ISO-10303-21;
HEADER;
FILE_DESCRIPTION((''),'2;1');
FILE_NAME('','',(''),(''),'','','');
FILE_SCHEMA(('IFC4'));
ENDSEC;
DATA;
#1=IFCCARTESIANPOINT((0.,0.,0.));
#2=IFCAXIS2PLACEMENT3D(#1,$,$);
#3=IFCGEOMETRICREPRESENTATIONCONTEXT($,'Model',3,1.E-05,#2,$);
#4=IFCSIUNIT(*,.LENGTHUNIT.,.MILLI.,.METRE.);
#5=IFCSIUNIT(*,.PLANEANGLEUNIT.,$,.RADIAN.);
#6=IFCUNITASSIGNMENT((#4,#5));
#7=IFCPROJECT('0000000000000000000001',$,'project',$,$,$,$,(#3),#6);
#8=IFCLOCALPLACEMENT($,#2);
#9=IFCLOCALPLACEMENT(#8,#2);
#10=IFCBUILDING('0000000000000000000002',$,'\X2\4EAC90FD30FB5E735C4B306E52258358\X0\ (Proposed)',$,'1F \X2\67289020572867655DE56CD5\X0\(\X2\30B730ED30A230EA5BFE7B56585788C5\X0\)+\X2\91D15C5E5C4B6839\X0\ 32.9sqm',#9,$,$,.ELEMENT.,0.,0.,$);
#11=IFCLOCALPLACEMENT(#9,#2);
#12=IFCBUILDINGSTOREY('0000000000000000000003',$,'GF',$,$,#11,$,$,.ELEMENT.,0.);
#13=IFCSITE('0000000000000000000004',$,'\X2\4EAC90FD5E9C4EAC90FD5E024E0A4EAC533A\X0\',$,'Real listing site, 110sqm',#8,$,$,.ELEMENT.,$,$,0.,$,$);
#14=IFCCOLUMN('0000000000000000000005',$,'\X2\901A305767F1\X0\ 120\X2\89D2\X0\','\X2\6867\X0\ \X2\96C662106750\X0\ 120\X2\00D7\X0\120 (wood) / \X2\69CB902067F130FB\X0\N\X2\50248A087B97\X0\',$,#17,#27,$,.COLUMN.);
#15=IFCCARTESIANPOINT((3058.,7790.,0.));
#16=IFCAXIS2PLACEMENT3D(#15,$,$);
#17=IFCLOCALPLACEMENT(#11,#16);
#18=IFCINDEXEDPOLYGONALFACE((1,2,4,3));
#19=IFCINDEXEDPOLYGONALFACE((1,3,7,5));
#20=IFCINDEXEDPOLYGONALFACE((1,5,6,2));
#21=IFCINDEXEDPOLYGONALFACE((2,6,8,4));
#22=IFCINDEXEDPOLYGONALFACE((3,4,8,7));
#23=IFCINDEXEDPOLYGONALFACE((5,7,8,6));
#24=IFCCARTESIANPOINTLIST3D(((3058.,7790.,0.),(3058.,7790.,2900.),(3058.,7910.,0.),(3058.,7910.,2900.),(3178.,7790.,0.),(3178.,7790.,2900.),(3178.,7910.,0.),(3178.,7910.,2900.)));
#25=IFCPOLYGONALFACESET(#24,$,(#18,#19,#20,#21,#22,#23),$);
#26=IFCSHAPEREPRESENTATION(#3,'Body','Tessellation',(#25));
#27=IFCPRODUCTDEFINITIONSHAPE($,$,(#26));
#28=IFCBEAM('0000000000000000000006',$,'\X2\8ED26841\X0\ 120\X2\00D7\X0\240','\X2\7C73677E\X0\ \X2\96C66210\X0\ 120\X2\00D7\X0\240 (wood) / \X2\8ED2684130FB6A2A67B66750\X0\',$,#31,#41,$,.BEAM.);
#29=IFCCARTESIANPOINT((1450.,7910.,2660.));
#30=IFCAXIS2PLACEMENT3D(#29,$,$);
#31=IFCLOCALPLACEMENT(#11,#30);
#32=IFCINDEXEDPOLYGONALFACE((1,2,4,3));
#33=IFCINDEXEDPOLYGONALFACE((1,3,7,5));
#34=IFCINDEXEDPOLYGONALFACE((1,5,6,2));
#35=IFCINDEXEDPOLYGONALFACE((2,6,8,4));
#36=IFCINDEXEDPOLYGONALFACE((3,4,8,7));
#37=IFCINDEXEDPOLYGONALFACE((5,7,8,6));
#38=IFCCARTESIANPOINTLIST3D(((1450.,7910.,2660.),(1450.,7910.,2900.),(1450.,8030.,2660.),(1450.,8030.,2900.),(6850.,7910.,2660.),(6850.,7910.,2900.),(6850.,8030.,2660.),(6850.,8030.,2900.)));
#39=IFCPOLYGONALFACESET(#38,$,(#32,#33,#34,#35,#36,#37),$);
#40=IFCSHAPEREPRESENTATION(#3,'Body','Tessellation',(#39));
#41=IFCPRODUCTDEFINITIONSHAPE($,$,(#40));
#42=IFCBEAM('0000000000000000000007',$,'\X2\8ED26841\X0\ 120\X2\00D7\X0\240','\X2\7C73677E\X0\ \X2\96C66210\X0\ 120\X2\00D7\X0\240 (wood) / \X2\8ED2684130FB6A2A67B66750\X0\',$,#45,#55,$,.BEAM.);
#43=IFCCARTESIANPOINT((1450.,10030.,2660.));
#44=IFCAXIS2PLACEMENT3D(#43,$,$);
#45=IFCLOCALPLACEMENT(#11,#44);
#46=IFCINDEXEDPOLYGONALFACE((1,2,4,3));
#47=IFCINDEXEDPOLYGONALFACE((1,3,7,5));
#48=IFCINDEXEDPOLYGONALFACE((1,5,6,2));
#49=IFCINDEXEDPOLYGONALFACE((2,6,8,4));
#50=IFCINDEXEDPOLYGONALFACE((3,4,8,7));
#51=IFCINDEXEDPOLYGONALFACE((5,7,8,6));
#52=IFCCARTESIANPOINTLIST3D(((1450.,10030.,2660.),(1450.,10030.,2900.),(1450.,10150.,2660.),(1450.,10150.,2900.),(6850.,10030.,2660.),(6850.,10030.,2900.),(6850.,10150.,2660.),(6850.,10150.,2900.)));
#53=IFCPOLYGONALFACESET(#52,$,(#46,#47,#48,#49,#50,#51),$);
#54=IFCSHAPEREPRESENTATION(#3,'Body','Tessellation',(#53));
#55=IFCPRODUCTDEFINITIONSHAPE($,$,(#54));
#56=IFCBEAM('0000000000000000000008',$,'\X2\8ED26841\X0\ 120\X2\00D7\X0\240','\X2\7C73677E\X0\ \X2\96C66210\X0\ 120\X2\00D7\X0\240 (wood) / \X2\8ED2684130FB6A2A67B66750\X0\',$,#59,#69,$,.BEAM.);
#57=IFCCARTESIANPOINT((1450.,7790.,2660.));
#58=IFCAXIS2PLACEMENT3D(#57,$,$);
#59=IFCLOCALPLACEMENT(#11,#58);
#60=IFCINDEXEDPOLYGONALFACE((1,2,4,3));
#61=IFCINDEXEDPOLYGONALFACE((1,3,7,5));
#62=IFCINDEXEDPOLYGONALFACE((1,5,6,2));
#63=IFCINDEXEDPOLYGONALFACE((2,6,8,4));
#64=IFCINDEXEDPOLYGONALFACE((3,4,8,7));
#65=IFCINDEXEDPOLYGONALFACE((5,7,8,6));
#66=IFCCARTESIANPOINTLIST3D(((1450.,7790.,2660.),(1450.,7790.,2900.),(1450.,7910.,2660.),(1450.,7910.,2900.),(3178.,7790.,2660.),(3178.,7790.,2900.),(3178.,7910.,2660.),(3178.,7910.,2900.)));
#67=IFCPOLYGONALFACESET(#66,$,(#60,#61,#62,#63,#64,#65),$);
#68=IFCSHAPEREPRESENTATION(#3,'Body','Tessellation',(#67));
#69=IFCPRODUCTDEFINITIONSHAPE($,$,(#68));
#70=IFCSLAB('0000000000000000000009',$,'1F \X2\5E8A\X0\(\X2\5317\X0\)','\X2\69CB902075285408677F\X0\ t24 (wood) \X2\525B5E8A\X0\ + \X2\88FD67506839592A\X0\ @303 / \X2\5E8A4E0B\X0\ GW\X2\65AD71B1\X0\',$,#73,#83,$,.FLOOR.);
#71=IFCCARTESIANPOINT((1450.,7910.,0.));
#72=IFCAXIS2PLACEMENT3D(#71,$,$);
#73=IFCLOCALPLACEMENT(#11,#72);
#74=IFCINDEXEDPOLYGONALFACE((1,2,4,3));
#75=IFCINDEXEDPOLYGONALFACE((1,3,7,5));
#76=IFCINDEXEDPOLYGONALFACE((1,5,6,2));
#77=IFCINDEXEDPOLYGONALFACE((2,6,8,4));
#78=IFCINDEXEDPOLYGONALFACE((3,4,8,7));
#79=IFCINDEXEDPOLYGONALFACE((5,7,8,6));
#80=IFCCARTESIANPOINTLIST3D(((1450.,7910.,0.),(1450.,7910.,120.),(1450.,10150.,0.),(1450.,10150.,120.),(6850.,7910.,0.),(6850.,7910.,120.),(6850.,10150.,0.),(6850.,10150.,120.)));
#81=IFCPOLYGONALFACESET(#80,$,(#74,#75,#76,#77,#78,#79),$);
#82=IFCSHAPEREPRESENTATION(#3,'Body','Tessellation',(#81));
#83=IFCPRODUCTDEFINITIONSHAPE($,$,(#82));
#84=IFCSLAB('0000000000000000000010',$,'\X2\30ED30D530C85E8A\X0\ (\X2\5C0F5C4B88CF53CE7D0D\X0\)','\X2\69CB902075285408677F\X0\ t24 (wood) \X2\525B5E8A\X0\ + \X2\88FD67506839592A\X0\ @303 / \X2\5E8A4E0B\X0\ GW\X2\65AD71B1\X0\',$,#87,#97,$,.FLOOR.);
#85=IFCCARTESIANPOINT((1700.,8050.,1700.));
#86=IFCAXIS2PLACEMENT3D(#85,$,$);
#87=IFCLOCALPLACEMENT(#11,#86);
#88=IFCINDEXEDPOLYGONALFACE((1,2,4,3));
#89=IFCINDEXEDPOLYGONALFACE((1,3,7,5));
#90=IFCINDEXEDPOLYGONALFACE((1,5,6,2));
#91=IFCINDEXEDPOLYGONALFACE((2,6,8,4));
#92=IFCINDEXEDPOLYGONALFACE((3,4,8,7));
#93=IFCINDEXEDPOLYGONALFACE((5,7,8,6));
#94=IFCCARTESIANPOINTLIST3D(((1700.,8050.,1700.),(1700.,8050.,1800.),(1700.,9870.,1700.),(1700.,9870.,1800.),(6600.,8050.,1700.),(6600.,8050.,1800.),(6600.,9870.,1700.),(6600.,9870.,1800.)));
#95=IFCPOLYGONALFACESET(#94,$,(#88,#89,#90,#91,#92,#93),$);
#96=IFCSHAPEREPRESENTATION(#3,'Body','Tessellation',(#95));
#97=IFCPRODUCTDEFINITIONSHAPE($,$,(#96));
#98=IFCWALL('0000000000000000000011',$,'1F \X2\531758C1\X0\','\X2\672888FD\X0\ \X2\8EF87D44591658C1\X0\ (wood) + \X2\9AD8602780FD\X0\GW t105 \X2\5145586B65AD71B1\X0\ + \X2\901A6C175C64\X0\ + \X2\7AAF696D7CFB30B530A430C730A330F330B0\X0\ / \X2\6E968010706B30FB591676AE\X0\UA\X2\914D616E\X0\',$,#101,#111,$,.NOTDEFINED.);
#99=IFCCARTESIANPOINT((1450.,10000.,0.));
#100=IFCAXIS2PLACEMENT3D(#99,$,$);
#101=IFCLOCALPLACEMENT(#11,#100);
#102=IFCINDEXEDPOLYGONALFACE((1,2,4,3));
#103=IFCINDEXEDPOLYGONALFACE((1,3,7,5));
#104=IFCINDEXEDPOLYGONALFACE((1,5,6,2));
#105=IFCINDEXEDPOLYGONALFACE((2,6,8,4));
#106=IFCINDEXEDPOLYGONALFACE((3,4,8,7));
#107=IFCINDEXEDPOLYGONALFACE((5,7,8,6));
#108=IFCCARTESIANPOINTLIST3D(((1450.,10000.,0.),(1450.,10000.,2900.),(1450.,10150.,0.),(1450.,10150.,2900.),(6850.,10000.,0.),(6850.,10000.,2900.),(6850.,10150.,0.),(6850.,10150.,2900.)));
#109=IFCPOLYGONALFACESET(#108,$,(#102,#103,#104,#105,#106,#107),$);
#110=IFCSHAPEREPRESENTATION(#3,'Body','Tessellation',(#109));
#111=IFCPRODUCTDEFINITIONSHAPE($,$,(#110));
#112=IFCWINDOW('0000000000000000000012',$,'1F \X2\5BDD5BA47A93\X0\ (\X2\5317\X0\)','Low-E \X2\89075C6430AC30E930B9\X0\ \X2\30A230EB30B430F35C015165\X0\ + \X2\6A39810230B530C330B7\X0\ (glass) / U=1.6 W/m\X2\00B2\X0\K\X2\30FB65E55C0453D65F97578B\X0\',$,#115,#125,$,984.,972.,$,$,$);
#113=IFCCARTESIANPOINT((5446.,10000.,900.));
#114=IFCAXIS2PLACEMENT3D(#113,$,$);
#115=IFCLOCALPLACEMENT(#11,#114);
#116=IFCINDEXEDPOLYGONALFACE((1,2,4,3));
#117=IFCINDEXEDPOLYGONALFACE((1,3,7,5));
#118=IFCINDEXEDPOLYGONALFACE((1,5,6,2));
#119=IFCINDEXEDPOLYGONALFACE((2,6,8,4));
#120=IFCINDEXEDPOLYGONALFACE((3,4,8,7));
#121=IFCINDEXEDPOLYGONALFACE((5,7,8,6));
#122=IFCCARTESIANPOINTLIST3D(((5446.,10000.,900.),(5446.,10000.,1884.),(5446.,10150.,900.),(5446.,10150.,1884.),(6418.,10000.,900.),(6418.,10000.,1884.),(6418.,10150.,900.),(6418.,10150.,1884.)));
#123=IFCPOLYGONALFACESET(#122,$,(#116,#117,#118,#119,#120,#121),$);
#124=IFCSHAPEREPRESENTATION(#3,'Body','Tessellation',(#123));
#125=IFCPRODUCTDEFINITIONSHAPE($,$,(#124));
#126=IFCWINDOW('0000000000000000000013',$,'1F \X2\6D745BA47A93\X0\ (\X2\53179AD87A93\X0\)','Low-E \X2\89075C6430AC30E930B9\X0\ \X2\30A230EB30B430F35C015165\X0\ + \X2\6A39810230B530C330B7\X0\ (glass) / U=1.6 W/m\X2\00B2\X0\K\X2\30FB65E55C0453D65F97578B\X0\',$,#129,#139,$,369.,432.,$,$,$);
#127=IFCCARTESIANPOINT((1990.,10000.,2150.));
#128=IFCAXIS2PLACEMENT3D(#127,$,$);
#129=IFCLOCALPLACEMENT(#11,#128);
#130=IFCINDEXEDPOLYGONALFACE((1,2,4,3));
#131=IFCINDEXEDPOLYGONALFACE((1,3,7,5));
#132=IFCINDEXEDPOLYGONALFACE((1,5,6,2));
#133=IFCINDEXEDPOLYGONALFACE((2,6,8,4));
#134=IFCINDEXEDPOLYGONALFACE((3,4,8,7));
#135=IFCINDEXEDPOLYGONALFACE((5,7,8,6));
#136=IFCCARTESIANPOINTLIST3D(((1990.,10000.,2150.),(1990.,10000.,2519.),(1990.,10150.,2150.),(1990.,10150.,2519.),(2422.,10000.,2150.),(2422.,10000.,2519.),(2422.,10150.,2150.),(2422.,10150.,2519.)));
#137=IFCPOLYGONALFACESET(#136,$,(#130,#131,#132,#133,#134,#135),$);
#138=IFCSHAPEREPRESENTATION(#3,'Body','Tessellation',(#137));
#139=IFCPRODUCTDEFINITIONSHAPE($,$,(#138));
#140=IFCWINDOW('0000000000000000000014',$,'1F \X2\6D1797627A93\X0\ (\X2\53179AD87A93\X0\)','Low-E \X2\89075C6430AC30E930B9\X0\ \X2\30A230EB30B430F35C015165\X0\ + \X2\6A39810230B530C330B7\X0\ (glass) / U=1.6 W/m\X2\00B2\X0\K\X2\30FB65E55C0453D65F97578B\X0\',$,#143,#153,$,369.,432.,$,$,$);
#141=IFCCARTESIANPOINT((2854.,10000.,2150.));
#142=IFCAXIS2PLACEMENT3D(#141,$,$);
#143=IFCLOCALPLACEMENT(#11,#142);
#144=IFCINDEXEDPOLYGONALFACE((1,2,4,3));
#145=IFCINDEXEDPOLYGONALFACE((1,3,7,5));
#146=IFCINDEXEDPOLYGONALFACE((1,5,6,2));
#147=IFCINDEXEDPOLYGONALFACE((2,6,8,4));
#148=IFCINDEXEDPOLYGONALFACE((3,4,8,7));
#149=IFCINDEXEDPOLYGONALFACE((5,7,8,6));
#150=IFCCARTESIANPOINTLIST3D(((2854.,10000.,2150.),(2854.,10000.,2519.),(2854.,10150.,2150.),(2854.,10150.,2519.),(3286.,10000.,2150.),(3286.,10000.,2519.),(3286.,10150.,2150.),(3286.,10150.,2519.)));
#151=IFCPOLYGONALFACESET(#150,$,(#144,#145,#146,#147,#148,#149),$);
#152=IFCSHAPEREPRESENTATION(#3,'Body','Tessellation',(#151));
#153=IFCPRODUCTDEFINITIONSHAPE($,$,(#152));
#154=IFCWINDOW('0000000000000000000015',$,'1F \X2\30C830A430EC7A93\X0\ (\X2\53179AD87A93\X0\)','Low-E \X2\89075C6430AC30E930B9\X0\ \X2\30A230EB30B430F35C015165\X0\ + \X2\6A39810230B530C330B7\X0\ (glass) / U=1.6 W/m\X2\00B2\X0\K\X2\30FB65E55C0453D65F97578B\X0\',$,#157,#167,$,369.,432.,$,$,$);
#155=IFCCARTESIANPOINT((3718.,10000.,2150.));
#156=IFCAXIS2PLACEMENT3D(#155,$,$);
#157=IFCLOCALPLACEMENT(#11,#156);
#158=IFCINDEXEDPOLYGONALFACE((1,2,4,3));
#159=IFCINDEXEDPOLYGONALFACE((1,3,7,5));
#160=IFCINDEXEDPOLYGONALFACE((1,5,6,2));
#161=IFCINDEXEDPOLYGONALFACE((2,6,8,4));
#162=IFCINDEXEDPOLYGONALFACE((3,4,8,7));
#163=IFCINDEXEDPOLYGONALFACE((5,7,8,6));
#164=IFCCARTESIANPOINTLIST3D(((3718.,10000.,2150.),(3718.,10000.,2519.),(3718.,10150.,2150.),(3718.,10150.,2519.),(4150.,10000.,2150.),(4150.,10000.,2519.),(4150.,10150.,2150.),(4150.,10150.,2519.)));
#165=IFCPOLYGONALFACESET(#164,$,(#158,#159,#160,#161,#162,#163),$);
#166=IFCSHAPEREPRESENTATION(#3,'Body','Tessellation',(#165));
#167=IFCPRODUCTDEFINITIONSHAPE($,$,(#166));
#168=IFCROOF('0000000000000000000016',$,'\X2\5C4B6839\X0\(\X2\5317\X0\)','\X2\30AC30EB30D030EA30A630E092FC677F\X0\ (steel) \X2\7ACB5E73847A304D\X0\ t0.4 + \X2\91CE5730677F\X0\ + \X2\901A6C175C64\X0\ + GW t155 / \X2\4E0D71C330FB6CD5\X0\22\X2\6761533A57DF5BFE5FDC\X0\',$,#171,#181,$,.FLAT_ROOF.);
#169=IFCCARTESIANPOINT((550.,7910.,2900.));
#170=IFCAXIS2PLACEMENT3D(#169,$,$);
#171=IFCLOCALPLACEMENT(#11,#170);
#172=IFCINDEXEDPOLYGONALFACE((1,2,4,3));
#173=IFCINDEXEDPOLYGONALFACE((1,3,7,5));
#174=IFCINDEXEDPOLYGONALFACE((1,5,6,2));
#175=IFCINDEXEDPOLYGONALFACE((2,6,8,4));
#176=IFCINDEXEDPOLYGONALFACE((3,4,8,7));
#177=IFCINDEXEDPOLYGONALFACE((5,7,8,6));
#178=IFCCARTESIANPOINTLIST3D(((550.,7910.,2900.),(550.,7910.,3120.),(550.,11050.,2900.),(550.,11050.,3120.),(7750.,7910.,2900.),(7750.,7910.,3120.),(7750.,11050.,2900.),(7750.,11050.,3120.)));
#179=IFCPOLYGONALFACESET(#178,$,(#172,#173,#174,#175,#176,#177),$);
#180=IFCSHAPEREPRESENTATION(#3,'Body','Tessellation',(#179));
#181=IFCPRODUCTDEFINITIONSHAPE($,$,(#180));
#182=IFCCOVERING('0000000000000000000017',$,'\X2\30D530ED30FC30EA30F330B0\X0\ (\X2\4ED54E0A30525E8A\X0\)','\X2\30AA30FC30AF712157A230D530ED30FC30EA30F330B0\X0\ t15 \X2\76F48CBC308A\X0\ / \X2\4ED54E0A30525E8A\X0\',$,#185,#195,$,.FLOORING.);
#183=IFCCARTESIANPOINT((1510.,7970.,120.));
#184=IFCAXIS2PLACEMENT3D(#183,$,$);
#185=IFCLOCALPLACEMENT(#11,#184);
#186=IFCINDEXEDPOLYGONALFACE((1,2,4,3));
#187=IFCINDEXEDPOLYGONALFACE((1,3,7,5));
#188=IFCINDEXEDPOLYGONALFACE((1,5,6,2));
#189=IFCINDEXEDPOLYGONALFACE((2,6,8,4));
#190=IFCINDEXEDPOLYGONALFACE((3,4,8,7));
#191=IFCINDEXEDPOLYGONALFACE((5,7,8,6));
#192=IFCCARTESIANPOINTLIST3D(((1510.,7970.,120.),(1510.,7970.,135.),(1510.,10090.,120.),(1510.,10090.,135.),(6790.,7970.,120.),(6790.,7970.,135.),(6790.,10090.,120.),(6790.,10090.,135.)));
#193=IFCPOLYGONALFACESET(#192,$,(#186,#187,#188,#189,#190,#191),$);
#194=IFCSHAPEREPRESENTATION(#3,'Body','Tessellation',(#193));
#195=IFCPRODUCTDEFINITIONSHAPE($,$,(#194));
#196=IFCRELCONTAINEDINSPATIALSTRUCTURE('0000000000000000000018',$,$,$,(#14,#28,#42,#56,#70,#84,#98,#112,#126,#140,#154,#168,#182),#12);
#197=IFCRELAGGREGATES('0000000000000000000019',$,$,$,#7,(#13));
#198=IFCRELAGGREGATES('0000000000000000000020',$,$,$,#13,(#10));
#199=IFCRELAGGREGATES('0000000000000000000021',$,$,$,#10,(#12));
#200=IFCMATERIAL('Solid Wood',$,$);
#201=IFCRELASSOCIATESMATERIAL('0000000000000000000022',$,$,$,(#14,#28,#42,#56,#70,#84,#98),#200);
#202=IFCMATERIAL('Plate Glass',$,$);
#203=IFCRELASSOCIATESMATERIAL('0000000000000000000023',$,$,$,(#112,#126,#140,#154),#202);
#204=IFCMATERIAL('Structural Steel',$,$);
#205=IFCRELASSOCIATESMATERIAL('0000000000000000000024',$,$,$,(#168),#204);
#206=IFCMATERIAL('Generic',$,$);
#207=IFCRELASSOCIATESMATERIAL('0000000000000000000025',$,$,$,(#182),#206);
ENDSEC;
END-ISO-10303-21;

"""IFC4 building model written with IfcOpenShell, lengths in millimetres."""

from ifc_helpers import new_model, si_unit, frame, frame_2d, origin, place, context, project, spatial, rectangle, extrude, material, element, fill, save


model = new_model("IFC4")

# Units and contexts
model_context = context("Model", 3, precision=1e-05, world=origin())
ifc_project = project(units=[si_unit("LENGTHUNIT", "METRE", prefix="MILLI"), si_unit("PLANEANGLEUNIT", "RADIAN")], contexts=[model_context])

# Site, building, storey
site_placement = place(None, origin())
site = spatial("IfcSite", under=ifc_project, at=site_placement, Name="京都府京都市上京区", ObjectType="Real listing site, 110sqm", CompositionType="ELEMENT", RefElevation=0.0)
building_placement = place(site_placement, origin())
building = spatial("IfcBuilding", under=site, at=building_placement, Name="京都・平屋の別荘 (Proposed)", ObjectType="1F 木造在来工法(シロアリ対策塗装)+金属屋根 32.9sqm", CompositionType="ELEMENT", ElevationOfRefHeight=0.0, ElevationOfTerrain=0.0)
storey_placement = place(building_placement, origin())
storey = spatial("IfcBuildingStorey", under=building, at=storey_placement, Name="GF", CompositionType="ELEMENT", Elevation=0.0)

# Column
ifc_material_1 = material(Name="Solid Wood")
column_1_placement = place(storey_placement, frame((3058.0, 7790.0, 0.0)))
element("IfcColumn", 1, at=column_1_placement, inside=storey, material=ifc_material_1, Name="通し柱 120角", Description="桧 集成材 120×120 (wood) / 構造柱・N値計算", PredefinedType="COLUMN", context=model_context, shape_type="SweptSolid", body=[
    extrude(rectangle(XDim=120.0, YDim=120.0, at=frame_2d((60.0, 60.0))), frame((3058.0, 7790.0, 0.0)), (0.0, 0.0, 1.0), 2900.0),
])

# Beams
beam_1_placement = place(storey_placement, frame((1450.0, 7910.0, 2660.0)))
element("IfcBeam", 2, at=beam_1_placement, inside=storey, material=ifc_material_1, Name="軒桁 120×240", Description="米松 集成 120×240 (wood) / 軒桁・横架材", PredefinedType="BEAM", context=model_context, shape_type="SweptSolid", body=[
    extrude(rectangle(XDim=5400.0, YDim=120.0, at=frame_2d((2700.0, 60.0))), frame((1450.0, 7910.0, 2660.0)), (0.0, 0.0, 1.0), 240.0),
])
beam_2_placement = place(storey_placement, frame((1450.0, 10030.0, 2660.0)))
element("IfcBeam", 3, at=beam_2_placement, inside=storey, material=ifc_material_1, Name="軒桁 120×240", Description="米松 集成 120×240 (wood) / 軒桁・横架材", PredefinedType="BEAM", context=model_context, shape_type="SweptSolid", body=[
    extrude(rectangle(XDim=5400.0, YDim=120.0, at=frame_2d((2700.0, 60.0))), frame((1450.0, 10030.0, 2660.0)), (0.0, 0.0, 1.0), 240.0),
])
beam_3_placement = place(storey_placement, frame((1450.0, 7790.0, 2660.0)))
element("IfcBeam", 4, at=beam_3_placement, inside=storey, material=ifc_material_1, Name="軒桁 120×240", Description="米松 集成 120×240 (wood) / 軒桁・横架材", PredefinedType="BEAM", context=model_context, shape_type="SweptSolid", body=[
    extrude(rectangle(XDim=1728.0, YDim=120.0, at=frame_2d((864.0, 60.0))), frame((1450.0, 7790.0, 2660.0)), (0.0, 0.0, 1.0), 240.0),
])

# Slabs
slab_1_placement = place(storey_placement, frame((1450.0, 7910.0, 0.0)))
element("IfcSlab", 5, at=slab_1_placement, inside=storey, material=ifc_material_1, Name="1F 床(北)", Description="構造用合板 t24 (wood) 剛床 + 製材根太 @303 / 床下 GW断熱", PredefinedType="FLOOR", context=model_context, shape_type="SweptSolid", body=[
    extrude(rectangle(XDim=5400.0, YDim=2240.0, at=frame_2d((2700.0, 1120.0))), frame((1450.0, 7910.0, 0.0)), (0.0, 0.0, 1.0), 120.0),
])
slab_2_placement = place(storey_placement, frame((1700.0, 8050.0, 1700.0)))
element("IfcSlab", 6, at=slab_2_placement, inside=storey, material=ifc_material_1, Name="ロフト床 (小屋裏収納)", Description="構造用合板 t24 (wood) 剛床 + 製材根太 @303 / 床下 GW断熱", PredefinedType="FLOOR", context=model_context, shape_type="SweptSolid", body=[
    extrude(rectangle(XDim=4900.0, YDim=1820.0, at=frame_2d((2450.0, 910.0))), frame((1700.0, 8050.0, 1700.0)), (0.0, 0.0, 1.0), 100.0),
])

# Wall, openings, windows
wall_1_placement = place(storey_placement, frame((1450.0, 10000.0, 0.0)))
wall_1 = element("IfcWall", 7, at=wall_1_placement, inside=storey, material=ifc_material_1, Name="1F 北壁", Description="木製 軸組外壁 (wood) + 高性能GW t105 充填断熱 + 通気層 + 窯業系サイディング / 準耐火・外皮UA配慮", PredefinedType="NOTDEFINED", context=model_context, shape_type="SweptSolid", body=[
    extrude(rectangle(XDim=5400.0, YDim=150.0, at=frame_2d((2700.0, 75.0))), frame((1450.0, 10000.0, 0.0)), (0.0, 0.0, 1.0), 2900.0),
])
opening_1_placement = place(storey_placement, frame((5446.0, 10000.0, 900.0)))
opening_1 = element("IfcOpeningElement", 8, at=opening_1_placement, cuts=wall_1, PredefinedType="NOTDEFINED", context=model_context, shape_type="SweptSolid", body=[
    extrude(rectangle(XDim=972.0, YDim=150.0, at=frame_2d((486.0, 75.0))), frame((5446.0, 10000.0, 900.0)), (0.0, 0.0, 1.0), 984.0),
])
opening_2_placement = place(storey_placement, frame((1990.0, 10000.0, 2150.0)))
opening_2 = element("IfcOpeningElement", 9, at=opening_2_placement, cuts=wall_1, PredefinedType="NOTDEFINED", context=model_context, shape_type="SweptSolid", body=[
    extrude(rectangle(XDim=432.0, YDim=150.0, at=frame_2d((216.0, 75.0))), frame((1990.0, 10000.0, 2150.0)), (0.0, 0.0, 1.0), 369.0),
])
opening_3_placement = place(storey_placement, frame((2854.0, 10000.0, 2150.0)))
opening_3 = element("IfcOpeningElement", 10, at=opening_3_placement, cuts=wall_1, PredefinedType="NOTDEFINED", context=model_context, shape_type="SweptSolid", body=[
    extrude(rectangle(XDim=432.0, YDim=150.0, at=frame_2d((216.0, 75.0))), frame((2854.0, 10000.0, 2150.0)), (0.0, 0.0, 1.0), 369.0),
])
opening_4_placement = place(storey_placement, frame((3718.0, 10000.0, 2150.0)))
opening_4 = element("IfcOpeningElement", 11, at=opening_4_placement, cuts=wall_1, PredefinedType="NOTDEFINED", context=model_context, shape_type="SweptSolid", body=[
    extrude(rectangle(XDim=432.0, YDim=150.0, at=frame_2d((216.0, 75.0))), frame((3718.0, 10000.0, 2150.0)), (0.0, 0.0, 1.0), 369.0),
])
ifc_material_2 = material(Name="Plate Glass")
window_1_placement = place(storey_placement, frame((5446.0, 10000.0, 900.0)))
window_1 = element("IfcWindow", 12, at=window_1_placement, inside=storey, material=ifc_material_2, Name="1F 寝室窓 (北)", Description="Low-E 複層ガラス アルゴン封入 + 樹脂サッシ (glass) / U=1.6 W/m²K・日射取得型", OverallHeight=984.0, OverallWidth=972.0, context=model_context, shape_type="SweptSolid", body=[
    extrude(rectangle(XDim=972.0, YDim=150.0, at=frame_2d((486.0, 75.0))), frame((5446.0, 10000.0, 900.0)), (0.0, 0.0, 1.0), 984.0),
])
fill(opening_1, window_1)
window_2_placement = place(storey_placement, frame((1990.0, 10000.0, 2150.0)))
window_2 = element("IfcWindow", 13, at=window_2_placement, inside=storey, material=ifc_material_2, Name="1F 浴室窓 (北高窓)", Description="Low-E 複層ガラス アルゴン封入 + 樹脂サッシ (glass) / U=1.6 W/m²K・日射取得型", OverallHeight=369.0, OverallWidth=432.0, context=model_context, shape_type="SweptSolid", body=[
    extrude(rectangle(XDim=432.0, YDim=150.0, at=frame_2d((216.0, 75.0))), frame((1990.0, 10000.0, 2150.0)), (0.0, 0.0, 1.0), 369.0),
])
fill(opening_2, window_2)
window_3_placement = place(storey_placement, frame((2854.0, 10000.0, 2150.0)))
window_3 = element("IfcWindow", 14, at=window_3_placement, inside=storey, material=ifc_material_2, Name="1F 洗面窓 (北高窓)", Description="Low-E 複層ガラス アルゴン封入 + 樹脂サッシ (glass) / U=1.6 W/m²K・日射取得型", OverallHeight=369.0, OverallWidth=432.0, context=model_context, shape_type="SweptSolid", body=[
    extrude(rectangle(XDim=432.0, YDim=150.0, at=frame_2d((216.0, 75.0))), frame((2854.0, 10000.0, 2150.0)), (0.0, 0.0, 1.0), 369.0),
])
fill(opening_3, window_3)
window_4_placement = place(storey_placement, frame((3718.0, 10000.0, 2150.0)))
window_4 = element("IfcWindow", 15, at=window_4_placement, inside=storey, material=ifc_material_2, Name="1F トイレ窓 (北高窓)", Description="Low-E 複層ガラス アルゴン封入 + 樹脂サッシ (glass) / U=1.6 W/m²K・日射取得型", OverallHeight=369.0, OverallWidth=432.0, context=model_context, shape_type="SweptSolid", body=[
    extrude(rectangle(XDim=432.0, YDim=150.0, at=frame_2d((216.0, 75.0))), frame((3718.0, 10000.0, 2150.0)), (0.0, 0.0, 1.0), 369.0),
])
fill(opening_4, window_4)

# Roof
ifc_material_3 = material(Name="Structural Steel")
roof_placement = place(storey_placement, frame((550.0, 7910.0, 2900.0)))
element("IfcRoof", 16, at=roof_placement, inside=storey, material=ifc_material_3, Name="屋根(北)", Description="ガルバリウム鋼板 (steel) 立平葺き t0.4 + 野地板 + 通気層 + GW t155 / 不燃・法22条区域対応", PredefinedType="FLAT_ROOF", context=model_context, shape_type="SweptSolid", body=[
    extrude(rectangle(XDim=7200.0, YDim=3140.0, at=frame_2d((3600.0, 1570.0))), frame((550.0, 7910.0, 2900.0)), (0.0, 0.0, 1.0), 220.0),
])

# Covering
ifc_material_4 = material(Name="Generic")
covering_1_placement = place(storey_placement, frame((1510.0, 7970.0, 120.0)))
element("IfcCovering", 17, at=covering_1_placement, inside=storey, material=ifc_material_4, Name="フローリング (仕上げ床)", Description="オーク無垢フローリング t15 直貼り / 仕上げ床", PredefinedType="FLOORING", context=model_context, shape_type="SweptSolid", body=[
    extrude(rectangle(XDim=5280.0, YDim=2120.0, at=frame_2d((2640.0, 1060.0))), frame((1510.0, 7970.0, 120.0)), (0.0, 0.0, 1.0), 15.0),
])

save(model, "model.ifc")
